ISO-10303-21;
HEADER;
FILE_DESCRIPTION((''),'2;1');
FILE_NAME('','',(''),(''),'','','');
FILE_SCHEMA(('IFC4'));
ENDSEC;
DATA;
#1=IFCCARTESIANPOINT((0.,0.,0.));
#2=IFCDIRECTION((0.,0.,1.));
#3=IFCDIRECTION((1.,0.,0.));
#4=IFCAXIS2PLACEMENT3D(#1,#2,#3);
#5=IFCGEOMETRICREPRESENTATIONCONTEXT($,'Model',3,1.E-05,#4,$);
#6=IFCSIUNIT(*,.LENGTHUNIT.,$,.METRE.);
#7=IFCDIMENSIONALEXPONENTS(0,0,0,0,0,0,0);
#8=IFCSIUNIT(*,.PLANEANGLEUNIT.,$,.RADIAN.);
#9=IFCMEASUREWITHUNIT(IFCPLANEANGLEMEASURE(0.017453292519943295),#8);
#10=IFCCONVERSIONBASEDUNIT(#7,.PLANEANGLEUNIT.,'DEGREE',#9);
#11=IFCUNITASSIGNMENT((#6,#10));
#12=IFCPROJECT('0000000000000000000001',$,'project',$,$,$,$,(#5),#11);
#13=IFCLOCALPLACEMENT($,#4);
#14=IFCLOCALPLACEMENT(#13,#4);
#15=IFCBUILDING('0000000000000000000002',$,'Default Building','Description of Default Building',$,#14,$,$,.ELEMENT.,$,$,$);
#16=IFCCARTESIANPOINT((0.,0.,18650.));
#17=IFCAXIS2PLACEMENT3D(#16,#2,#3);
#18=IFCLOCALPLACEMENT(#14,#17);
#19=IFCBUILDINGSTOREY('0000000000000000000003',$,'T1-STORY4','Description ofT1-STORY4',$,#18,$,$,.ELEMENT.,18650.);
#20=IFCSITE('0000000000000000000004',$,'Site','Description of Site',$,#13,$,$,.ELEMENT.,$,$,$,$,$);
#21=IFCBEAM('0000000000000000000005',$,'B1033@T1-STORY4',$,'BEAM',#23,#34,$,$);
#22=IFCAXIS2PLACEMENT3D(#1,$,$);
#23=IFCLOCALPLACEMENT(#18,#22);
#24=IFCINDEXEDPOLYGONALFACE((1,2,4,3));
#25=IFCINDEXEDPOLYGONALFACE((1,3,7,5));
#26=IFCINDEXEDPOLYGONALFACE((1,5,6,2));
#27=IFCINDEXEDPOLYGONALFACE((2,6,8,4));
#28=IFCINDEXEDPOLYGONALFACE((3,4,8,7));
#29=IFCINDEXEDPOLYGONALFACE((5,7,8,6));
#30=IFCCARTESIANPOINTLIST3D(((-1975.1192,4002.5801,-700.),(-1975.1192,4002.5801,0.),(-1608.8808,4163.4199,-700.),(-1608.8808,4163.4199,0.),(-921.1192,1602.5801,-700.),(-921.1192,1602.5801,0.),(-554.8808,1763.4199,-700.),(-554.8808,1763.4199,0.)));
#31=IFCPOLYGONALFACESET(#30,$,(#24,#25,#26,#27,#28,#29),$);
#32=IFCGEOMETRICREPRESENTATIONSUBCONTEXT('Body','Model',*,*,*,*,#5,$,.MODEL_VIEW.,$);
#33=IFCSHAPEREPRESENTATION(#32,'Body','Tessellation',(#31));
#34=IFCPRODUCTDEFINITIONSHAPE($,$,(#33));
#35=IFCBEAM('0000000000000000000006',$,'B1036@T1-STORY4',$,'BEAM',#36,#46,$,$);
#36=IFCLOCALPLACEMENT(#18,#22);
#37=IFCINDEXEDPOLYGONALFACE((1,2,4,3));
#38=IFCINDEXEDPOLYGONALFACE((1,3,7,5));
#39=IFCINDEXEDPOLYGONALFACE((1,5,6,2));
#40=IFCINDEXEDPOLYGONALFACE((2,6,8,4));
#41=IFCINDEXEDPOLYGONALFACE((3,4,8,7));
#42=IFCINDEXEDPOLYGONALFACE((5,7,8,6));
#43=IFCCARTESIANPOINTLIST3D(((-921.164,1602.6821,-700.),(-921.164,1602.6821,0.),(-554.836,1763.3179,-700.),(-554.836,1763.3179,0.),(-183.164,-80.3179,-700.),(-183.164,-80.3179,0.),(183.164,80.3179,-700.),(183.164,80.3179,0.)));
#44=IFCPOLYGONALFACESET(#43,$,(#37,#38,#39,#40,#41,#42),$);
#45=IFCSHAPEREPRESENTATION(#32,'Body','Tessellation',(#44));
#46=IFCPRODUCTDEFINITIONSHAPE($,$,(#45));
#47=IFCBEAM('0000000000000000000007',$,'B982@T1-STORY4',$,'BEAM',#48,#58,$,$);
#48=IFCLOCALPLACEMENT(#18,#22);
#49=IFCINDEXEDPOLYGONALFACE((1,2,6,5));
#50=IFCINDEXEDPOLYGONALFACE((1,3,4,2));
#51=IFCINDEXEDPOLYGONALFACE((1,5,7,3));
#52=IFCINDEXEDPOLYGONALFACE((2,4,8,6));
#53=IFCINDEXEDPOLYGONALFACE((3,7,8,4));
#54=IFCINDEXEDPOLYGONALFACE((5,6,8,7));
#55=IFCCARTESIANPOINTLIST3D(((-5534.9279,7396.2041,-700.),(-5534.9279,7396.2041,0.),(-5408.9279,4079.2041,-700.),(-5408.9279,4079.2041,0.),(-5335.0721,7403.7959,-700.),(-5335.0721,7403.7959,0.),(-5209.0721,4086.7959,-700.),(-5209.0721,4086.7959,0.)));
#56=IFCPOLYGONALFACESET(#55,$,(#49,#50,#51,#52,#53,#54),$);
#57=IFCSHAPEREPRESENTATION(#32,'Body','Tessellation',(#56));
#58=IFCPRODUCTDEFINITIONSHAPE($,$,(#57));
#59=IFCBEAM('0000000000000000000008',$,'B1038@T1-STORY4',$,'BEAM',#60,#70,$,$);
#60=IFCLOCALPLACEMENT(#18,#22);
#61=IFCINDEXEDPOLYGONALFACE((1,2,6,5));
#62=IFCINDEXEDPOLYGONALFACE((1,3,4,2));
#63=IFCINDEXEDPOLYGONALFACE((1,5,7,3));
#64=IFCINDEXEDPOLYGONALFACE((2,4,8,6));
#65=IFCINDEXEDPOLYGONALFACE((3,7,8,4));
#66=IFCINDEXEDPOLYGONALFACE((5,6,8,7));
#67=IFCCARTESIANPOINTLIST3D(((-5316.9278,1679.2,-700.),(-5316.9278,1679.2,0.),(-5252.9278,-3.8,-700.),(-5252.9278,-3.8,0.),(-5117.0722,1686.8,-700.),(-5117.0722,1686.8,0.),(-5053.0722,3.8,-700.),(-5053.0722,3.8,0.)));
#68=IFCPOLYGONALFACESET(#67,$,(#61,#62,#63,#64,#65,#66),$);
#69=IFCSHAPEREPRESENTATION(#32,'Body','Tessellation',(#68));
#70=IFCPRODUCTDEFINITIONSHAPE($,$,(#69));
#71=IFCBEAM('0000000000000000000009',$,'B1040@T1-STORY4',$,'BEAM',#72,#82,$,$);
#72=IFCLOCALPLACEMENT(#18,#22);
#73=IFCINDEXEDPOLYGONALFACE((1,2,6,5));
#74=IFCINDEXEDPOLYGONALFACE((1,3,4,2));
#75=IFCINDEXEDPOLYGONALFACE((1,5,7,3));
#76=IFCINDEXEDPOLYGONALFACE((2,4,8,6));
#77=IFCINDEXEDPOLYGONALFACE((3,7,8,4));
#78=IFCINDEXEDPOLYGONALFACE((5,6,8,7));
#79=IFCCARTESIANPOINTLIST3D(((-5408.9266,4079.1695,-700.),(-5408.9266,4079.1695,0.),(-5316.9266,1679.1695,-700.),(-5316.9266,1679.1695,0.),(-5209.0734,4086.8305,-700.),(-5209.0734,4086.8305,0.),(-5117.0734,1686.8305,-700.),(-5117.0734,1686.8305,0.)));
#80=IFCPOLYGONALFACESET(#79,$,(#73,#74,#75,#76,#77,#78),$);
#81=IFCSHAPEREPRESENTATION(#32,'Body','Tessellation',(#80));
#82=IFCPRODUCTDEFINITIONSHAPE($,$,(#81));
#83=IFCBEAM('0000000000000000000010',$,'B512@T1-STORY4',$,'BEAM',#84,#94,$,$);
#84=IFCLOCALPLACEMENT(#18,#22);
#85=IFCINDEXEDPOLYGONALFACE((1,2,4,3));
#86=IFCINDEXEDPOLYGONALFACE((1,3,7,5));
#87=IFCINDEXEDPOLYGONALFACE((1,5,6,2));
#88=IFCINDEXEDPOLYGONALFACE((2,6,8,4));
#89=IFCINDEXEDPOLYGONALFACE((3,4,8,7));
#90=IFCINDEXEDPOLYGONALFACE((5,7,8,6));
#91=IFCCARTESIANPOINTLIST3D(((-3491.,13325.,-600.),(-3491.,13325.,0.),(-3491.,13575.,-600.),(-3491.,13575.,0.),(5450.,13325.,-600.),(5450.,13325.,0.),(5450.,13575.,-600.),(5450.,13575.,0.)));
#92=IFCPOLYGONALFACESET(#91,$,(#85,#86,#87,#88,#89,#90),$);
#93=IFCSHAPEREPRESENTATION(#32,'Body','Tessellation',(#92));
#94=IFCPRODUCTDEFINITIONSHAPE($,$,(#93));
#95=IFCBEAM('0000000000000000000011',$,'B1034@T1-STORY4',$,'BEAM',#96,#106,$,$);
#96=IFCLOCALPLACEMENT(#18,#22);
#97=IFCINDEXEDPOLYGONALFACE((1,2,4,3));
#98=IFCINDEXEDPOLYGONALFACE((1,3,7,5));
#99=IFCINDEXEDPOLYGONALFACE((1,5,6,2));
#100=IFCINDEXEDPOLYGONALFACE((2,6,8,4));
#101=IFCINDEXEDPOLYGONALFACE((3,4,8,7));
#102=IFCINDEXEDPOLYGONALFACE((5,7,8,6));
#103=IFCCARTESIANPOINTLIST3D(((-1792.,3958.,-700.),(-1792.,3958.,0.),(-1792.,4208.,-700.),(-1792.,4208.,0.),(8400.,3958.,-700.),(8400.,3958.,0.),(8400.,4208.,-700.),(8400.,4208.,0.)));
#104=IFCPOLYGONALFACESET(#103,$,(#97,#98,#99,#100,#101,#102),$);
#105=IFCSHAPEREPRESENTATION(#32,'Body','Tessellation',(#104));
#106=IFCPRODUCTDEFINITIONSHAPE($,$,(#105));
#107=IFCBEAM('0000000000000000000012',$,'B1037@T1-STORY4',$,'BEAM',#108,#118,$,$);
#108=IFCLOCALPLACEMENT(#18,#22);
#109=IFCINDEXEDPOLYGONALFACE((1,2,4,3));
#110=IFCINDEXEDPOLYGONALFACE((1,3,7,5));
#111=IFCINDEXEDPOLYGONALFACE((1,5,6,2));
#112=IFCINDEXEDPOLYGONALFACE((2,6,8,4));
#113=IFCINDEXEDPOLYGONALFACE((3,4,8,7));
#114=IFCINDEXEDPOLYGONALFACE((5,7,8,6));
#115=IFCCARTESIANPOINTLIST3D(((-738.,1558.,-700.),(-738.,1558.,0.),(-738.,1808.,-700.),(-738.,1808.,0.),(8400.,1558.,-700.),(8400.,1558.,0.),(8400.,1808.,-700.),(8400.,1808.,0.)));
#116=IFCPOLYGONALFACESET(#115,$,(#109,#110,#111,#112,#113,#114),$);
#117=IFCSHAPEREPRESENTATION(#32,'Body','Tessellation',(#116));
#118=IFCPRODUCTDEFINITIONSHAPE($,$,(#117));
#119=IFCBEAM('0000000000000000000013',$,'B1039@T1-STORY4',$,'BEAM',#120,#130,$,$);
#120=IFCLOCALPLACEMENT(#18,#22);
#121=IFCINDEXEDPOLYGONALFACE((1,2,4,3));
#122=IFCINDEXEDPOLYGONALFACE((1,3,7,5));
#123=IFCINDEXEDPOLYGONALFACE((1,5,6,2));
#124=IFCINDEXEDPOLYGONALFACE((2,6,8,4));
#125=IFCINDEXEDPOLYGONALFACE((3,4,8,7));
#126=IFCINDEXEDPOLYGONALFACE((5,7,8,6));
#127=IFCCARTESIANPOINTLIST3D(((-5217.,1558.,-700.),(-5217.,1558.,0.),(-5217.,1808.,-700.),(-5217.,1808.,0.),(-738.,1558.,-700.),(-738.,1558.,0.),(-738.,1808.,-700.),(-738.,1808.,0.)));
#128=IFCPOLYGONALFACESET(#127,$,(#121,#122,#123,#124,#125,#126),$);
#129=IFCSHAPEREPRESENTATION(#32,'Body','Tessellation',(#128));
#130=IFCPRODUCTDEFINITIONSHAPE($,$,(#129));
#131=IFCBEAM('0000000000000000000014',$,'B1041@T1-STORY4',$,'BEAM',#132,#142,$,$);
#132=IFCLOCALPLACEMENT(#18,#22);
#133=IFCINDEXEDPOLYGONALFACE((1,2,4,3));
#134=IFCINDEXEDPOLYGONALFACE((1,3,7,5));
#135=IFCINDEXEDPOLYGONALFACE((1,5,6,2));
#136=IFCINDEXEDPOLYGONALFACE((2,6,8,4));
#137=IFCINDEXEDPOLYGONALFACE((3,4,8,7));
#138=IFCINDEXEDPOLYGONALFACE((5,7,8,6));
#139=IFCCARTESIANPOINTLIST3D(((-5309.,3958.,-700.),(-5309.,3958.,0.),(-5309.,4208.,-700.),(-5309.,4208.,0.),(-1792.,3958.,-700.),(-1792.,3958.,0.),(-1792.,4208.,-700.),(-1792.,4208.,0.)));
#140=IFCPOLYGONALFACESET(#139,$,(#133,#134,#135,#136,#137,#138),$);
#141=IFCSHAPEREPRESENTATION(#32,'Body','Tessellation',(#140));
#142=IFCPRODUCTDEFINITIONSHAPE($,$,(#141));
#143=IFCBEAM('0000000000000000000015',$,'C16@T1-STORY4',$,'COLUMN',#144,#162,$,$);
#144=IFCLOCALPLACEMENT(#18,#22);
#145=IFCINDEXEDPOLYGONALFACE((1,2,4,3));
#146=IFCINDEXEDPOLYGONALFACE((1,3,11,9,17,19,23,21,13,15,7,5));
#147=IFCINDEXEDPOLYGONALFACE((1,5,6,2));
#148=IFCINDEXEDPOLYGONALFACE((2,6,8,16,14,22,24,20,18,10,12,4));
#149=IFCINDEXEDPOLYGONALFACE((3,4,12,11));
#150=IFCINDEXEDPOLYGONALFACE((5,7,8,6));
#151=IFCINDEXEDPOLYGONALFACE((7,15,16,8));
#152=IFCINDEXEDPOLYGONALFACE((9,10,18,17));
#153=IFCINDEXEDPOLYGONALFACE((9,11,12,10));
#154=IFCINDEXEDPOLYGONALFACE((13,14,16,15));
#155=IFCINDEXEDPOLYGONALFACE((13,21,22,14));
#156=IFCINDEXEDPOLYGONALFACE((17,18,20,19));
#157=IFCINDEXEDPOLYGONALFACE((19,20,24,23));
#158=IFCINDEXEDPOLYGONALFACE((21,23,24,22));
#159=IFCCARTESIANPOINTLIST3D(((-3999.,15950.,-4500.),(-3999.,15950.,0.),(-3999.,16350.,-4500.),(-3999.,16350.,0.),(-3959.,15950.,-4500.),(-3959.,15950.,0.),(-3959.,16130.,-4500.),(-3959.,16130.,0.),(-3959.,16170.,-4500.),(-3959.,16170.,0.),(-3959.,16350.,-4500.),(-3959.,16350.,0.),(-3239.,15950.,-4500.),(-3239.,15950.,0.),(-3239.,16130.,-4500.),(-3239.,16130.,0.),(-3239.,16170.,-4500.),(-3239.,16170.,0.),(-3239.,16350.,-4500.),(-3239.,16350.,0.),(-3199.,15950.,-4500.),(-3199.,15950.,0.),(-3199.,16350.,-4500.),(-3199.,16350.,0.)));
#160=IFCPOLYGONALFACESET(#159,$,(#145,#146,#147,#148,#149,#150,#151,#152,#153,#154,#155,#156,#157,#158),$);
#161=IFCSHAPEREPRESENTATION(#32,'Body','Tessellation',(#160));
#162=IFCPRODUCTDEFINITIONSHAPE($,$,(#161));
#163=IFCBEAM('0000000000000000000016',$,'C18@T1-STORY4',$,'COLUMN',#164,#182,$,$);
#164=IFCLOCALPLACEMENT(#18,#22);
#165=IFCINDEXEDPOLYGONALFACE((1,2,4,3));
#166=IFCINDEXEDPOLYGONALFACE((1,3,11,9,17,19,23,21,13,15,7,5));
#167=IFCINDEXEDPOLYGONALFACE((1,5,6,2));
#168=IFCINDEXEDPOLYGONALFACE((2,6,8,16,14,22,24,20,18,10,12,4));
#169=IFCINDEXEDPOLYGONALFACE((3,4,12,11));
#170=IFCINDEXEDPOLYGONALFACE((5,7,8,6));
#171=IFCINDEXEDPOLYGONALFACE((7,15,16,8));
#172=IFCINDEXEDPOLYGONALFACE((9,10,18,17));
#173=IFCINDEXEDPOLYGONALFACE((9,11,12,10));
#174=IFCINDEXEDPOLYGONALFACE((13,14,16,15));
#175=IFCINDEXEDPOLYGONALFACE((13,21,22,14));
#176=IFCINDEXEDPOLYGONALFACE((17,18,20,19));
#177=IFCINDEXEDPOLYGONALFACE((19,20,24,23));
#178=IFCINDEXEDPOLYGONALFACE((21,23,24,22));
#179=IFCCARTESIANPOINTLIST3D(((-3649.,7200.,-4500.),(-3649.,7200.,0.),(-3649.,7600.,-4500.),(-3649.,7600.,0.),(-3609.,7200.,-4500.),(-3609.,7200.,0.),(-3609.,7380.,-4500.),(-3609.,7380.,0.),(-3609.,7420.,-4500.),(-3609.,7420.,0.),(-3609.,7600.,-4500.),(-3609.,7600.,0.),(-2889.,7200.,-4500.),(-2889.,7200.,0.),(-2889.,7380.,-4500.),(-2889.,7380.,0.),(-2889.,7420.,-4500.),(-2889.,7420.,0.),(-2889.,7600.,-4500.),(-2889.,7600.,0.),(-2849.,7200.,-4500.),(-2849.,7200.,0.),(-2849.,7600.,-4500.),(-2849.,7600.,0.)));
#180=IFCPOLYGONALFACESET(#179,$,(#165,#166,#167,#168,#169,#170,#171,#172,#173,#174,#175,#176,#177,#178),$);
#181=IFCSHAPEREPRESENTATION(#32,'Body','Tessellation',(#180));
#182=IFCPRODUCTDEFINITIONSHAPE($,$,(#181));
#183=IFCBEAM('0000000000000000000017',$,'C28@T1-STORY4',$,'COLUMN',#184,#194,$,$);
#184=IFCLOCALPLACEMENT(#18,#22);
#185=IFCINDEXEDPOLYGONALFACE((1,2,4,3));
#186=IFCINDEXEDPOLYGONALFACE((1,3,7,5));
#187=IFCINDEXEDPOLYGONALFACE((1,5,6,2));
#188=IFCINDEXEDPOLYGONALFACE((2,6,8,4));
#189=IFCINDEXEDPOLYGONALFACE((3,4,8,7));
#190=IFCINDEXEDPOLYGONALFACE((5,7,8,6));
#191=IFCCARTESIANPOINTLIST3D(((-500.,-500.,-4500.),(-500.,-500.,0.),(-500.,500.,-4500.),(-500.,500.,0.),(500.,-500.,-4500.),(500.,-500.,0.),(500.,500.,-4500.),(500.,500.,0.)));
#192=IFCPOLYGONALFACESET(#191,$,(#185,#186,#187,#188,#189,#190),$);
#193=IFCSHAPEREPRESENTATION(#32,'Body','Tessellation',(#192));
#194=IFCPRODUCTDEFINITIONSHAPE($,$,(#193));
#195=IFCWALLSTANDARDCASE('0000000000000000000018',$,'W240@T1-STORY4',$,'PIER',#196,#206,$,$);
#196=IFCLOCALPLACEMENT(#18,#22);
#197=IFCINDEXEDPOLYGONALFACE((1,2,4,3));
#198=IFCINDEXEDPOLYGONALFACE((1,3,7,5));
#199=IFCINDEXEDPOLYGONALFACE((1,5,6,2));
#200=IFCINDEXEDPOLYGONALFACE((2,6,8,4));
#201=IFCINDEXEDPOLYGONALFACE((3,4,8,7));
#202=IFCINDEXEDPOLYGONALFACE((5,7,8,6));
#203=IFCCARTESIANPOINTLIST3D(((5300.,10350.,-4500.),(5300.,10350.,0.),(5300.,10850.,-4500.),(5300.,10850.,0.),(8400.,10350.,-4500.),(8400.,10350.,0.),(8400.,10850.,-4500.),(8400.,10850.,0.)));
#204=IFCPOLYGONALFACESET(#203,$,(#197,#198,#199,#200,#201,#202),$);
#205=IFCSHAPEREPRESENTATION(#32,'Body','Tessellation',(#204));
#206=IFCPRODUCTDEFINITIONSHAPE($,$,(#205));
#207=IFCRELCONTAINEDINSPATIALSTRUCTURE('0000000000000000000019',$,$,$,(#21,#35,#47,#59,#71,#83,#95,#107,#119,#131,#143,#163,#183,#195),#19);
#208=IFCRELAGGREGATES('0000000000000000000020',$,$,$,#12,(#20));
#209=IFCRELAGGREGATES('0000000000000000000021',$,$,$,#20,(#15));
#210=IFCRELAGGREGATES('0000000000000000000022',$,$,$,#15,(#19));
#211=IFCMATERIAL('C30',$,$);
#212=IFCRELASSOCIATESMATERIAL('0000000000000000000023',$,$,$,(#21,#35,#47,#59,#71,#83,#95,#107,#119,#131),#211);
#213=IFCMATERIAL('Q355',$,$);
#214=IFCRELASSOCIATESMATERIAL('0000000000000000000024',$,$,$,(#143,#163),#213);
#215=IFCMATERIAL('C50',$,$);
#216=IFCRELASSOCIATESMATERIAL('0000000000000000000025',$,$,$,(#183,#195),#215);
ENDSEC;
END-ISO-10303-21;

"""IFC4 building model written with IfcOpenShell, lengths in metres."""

from ifc_helpers import new_model, entity, si_unit, converted_unit, frame, origin_with_axes, place, context, subcontext, project, spatial, indexed_curve, rectangle, i_section, outline, extrude, material, element, save


model = new_model("IFC4")

# Units and contexts
model_context = context("Model", 3, precision=1e-05, world=origin_with_axes())
body_context = subcontext(model_context, "Body", "Model", "MODEL_VIEW")
ifc_project = project(units=[si_unit("LENGTHUNIT", "METRE"), converted_unit("PLANEANGLEUNIT", "DEGREE", entity("IfcPlaneAngleMeasure", 0.017453292519943295), si_unit("PLANEANGLEUNIT", "RADIAN"), dimensions=[0, 0, 0, 0, 0, 0, 0])], contexts=[model_context])

# Site, building, storey
site_placement = place(None, origin_with_axes())
site = spatial("IfcSite", under=ifc_project, at=site_placement, Name="Site", Description="Description of Site", CompositionType="ELEMENT")
building_placement = place(site_placement, origin_with_axes())
building = spatial("IfcBuilding", under=site, at=building_placement, Name="Default Building", Description="Description of Default Building", CompositionType="ELEMENT")
storey_placement = place(building_placement, frame((0.0, 0.0, 18650.0), z_axis=(0.0, 0.0, 1.0), x_axis=(1.0, 0.0, 0.0)))
storey = spatial("IfcBuildingStorey", under=building, at=storey_placement, Name="T1-STORY4", Description="Description ofT1-STORY4", CompositionType="ELEMENT", Elevation=18650.0)

# Beams
ifc_material_1 = material(Name="C30")
beam_1_placement = place(storey_placement, frame((-1792.0, 4083.0, -350.0), z_axis=(0.402099, -0.915596, 0.0), x_axis=(0.915596, 0.402099, 0.0)))
element("IfcBeam", 1, at=beam_1_placement, inside=storey, material=ifc_material_1, Name="B1033@T1-STORY4", ObjectType="BEAM", context=body_context, shape_type="SweptSolid", body=[
    extrude(rectangle(XDim=400.0, YDim=700.0), origin_with_axes(), (0.0, 0.0, 1.0), 2621.2432),
])
beam_2_placement = place(storey_placement, frame((-738.0, 1683.0, -350.0), z_axis=(0.401589, -0.91582, 0.0), x_axis=(0.91582, 0.401589, 0.0)))
element("IfcBeam", 2, at=beam_2_placement, inside=storey, material=ifc_material_1, Name="B1036@T1-STORY4", ObjectType="BEAM", context=body_context, shape_type="SweptSolid", body=[
    extrude(rectangle(XDim=400.0, YDim=700.0), origin_with_axes(), (0.0, 0.0, 1.0), 1837.6977),
])
beam_3_placement = place(storey_placement, frame((-5435.0, 7400.0, -350.0), z_axis=(0.037959, -0.999279, 0.0), x_axis=(0.999279, 0.037959, 0.0)))
element("IfcBeam", 3, at=beam_3_placement, inside=storey, material=ifc_material_1, Name="B982@T1-STORY4", ObjectType="BEAM", context=body_context, shape_type="SweptSolid", body=[
    extrude(rectangle(XDim=200.0, YDim=700.0), origin_with_axes(), (0.0, 0.0, 1.0), 3319.3923),
])
beam_4_placement = place(storey_placement, frame((-5217.0, 1683.0, -350.0), z_axis=(0.038, -0.999278, 0.0), x_axis=(0.999278, 0.038, 0.0)))
element("IfcBeam", 4, at=beam_4_placement, inside=storey, material=ifc_material_1, Name="B1038@T1-STORY4", ObjectType="BEAM", context=body_context, shape_type="SweptSolid", body=[
    extrude(rectangle(XDim=200.0, YDim=700.0), origin_with_axes(), (0.0, 0.0, 1.0), 1684.2164),
])
beam_5_placement = place(storey_placement, frame((-5309.0, 4083.0, -350.0), z_axis=(0.038305, -0.999266, 0.0), x_axis=(0.999266, 0.038305, 0.0)))
element("IfcBeam", 5, at=beam_5_placement, inside=storey, material=ifc_material_1, Name="B1040@T1-STORY4", ObjectType="BEAM", context=body_context, shape_type="SweptSolid", body=[
    extrude(rectangle(XDim=200.0, YDim=700.0), origin_with_axes(), (0.0, 0.0, 1.0), 2401.7627),
])
beam_6_placement = place(storey_placement, frame((-3491.0, 13450.0, -300.0), z_axis=(1.0, 0.0, 0.0), x_axis=(0.0, 1.0, 0.0)))
element("IfcBeam", 6, at=beam_6_placement, inside=storey, material=ifc_material_1, Name="B512@T1-STORY4", ObjectType="BEAM", context=body_context, shape_type="SweptSolid", body=[
    extrude(rectangle(XDim=250.0, YDim=600.0), origin_with_axes(), (0.0, 0.0, 1.0), 8941.0),
])
beam_7_placement = place(storey_placement, frame((-1792.0, 4083.0, -350.0), z_axis=(1.0, 0.0, 0.0), x_axis=(0.0, 1.0, 0.0)))
element("IfcBeam", 7, at=beam_7_placement, inside=storey, material=ifc_material_1, Name="B1034@T1-STORY4", ObjectType="BEAM", context=body_context, shape_type="SweptSolid", body=[
    extrude(rectangle(XDim=250.0, YDim=700.0), origin_with_axes(), (0.0, 0.0, 1.0), 10192.0),
])
beam_8_placement = place(storey_placement, frame((-738.0, 1683.0, -350.0), z_axis=(1.0, 0.0, 0.0), x_axis=(0.0, 1.0, 0.0)))
element("IfcBeam", 8, at=beam_8_placement, inside=storey, material=ifc_material_1, Name="B1037@T1-STORY4", ObjectType="BEAM", context=body_context, shape_type="SweptSolid", body=[
    extrude(rectangle(XDim=250.0, YDim=700.0), origin_with_axes(), (0.0, 0.0, 1.0), 9138.0),
])
beam_9_placement = place(storey_placement, frame((-5217.0, 1683.0, -350.0), z_axis=(1.0, 0.0, 0.0), x_axis=(0.0, 1.0, 0.0)))
element("IfcBeam", 9, at=beam_9_placement, inside=storey, material=ifc_material_1, Name="B1039@T1-STORY4", ObjectType="BEAM", context=body_context, shape_type="SweptSolid", body=[
    extrude(rectangle(XDim=250.0, YDim=700.0), origin_with_axes(), (0.0, 0.0, 1.0), 4479.0),
])
beam_10_placement = place(storey_placement, frame((-5309.0, 4083.0, -350.0), z_axis=(1.0, 0.0, 0.0), x_axis=(0.0, 1.0, 0.0)))
element("IfcBeam", 10, at=beam_10_placement, inside=storey, material=ifc_material_1, Name="B1041@T1-STORY4", ObjectType="BEAM", context=body_context, shape_type="SweptSolid", body=[
    extrude(rectangle(XDim=250.0, YDim=700.0), origin_with_axes(), (0.0, 0.0, 1.0), 3517.0),
])
ifc_material_2 = material(Name="C50")
ifc_material_3 = material(Name="Q355")
beam_11_placement = place(storey_placement, frame((-3599.0, 16150.0, -4500.0), z_axis=(0.0, 0.0, 1.0), x_axis=(0.0, -1.0, 0.0)))
element("IfcBeam", 11, at=beam_11_placement, inside=storey, material=ifc_material_3, Name="C16@T1-STORY4", ObjectType="COLUMN", context=body_context, shape_type="SweptSolid", body=[
    extrude(i_section(OverallWidth=400.0, OverallDepth=800.0, WebThickness=40.0, FlangeThickness=40.0, FilletRadius=0.0), origin_with_axes(), (0.0, 0.0, 1.0), 4500.0),
])
beam_12_placement = place(storey_placement, frame((-3249.0, 7400.0, -4500.0), z_axis=(0.0, 0.0, 1.0), x_axis=(0.0, -1.0, 0.0)))
element("IfcBeam", 12, at=beam_12_placement, inside=storey, material=ifc_material_3, Name="C18@T1-STORY4", ObjectType="COLUMN", context=body_context, shape_type="SweptSolid", body=[
    extrude(i_section(OverallWidth=400.0, OverallDepth=800.0, WebThickness=40.0, FlangeThickness=40.0, FilletRadius=0.0), origin_with_axes(), (0.0, 0.0, 1.0), 4500.0),
])
beam_13_placement = place(storey_placement, frame((0.0, 0.0, -4500.0), z_axis=(0.0, 0.0, 1.0), x_axis=(-1.0, 0.0, 0.0)))
element("IfcBeam", 13, at=beam_13_placement, inside=storey, material=ifc_material_2, Name="C28@T1-STORY4", ObjectType="COLUMN", context=body_context, shape_type="SweptSolid", body=[
    extrude(rectangle(XDim=1000.0, YDim=1000.0), origin_with_axes(), (0.0, 0.0, 1.0), 4500.0),
])

# Wall
wall_1_placement = place(storey_placement, frame((5300.0, 10600.0, -4500.0), z_axis=(0.0, 0.0, 1.0), x_axis=(1.0, 0.0, 0.0)))
element("IfcWallStandardCase", 14, at=wall_1_placement, inside=storey, material=ifc_material_2, Name="W240@T1-STORY4", ObjectType="PIER", context=body_context, shape_type="SweptSolid", body=[
    extrude(outline(indexed_curve([(0.0, -250.0), (0.0, 250.0), (3100.0, 250.0), (3100.0, -250.0), (0.0, -250.0)], self_intersect=False)), origin_with_axes(), (0.0, 0.0, 1.0), 4500.0),
])

save(model, "model.ifc")
